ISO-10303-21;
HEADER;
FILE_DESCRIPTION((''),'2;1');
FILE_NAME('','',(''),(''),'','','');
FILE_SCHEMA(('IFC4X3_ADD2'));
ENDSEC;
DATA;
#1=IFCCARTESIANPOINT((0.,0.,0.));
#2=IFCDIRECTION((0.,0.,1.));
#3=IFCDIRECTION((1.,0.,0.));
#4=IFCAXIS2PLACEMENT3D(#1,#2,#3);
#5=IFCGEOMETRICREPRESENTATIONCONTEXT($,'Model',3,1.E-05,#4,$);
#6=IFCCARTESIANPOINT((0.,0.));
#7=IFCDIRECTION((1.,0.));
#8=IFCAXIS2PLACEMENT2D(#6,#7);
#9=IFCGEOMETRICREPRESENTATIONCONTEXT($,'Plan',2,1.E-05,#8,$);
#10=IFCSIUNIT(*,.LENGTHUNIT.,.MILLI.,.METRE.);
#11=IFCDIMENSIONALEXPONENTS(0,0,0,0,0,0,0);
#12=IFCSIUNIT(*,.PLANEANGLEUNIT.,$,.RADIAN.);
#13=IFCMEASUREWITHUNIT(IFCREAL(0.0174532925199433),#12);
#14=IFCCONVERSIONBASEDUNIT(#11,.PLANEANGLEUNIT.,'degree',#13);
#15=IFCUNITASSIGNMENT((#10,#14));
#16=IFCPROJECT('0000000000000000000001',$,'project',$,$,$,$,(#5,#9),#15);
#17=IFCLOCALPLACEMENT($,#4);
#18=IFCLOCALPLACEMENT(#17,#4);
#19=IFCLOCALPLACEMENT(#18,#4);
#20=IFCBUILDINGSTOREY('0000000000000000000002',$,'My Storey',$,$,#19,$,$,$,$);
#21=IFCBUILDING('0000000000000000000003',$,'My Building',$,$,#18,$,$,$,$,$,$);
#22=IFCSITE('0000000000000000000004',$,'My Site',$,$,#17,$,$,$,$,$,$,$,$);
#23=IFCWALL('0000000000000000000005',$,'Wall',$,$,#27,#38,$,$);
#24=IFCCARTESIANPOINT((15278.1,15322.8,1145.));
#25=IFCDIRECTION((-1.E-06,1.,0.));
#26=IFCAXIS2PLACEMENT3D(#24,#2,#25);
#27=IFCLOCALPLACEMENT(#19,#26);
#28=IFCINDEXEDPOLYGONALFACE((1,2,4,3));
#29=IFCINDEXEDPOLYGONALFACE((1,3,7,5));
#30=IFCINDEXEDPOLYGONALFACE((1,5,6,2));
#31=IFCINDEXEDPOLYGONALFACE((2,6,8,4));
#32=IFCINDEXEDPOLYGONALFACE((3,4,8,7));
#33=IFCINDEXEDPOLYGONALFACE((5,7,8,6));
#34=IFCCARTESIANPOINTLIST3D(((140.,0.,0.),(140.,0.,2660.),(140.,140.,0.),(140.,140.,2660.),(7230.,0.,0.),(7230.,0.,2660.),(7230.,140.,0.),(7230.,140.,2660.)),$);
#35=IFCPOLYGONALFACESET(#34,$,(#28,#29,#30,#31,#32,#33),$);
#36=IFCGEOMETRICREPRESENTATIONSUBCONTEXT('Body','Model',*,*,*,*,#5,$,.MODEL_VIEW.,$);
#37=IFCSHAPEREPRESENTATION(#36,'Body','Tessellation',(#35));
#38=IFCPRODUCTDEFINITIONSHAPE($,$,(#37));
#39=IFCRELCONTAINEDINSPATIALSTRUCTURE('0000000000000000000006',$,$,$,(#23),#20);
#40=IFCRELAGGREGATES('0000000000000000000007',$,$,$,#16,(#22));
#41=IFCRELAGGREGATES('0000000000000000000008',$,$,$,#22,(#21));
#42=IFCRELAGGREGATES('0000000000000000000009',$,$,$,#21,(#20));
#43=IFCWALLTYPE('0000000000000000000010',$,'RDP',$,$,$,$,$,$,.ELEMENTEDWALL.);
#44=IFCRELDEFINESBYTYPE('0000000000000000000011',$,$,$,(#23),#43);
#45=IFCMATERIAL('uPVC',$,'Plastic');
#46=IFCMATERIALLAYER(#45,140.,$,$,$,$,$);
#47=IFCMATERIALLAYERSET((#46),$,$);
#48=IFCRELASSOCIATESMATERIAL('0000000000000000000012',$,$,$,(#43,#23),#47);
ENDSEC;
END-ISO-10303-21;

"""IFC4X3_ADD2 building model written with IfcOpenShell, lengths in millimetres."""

from ifc_helpers import new_model, entity, si_unit, converted_unit, frame, origin_with_axes, origin_2d_with_axis, place, context, subcontext, project, spatial, line, indexed_curve, outline, extrude, material, layer, layer_set, layer_usage, type_object, element, save


model = new_model("IFC4X3_ADD2")

# Units and contexts
model_context = context("Model", 3, precision=1e-05, world=origin_with_axes())
plan_context = context("Plan", 2, precision=1e-05, world=origin_2d_with_axis())
body_context_1 = subcontext(model_context, "Body", "Model", "MODEL_VIEW")
ifc_project = project(units=[si_unit("LENGTHUNIT", "METRE", prefix="MILLI"), converted_unit("PLANEANGLEUNIT", "degree", entity("IfcReal", 0.0174532925199433), si_unit("PLANEANGLEUNIT", "RADIAN"), dimensions=[0, 0, 0, 0, 0, 0, 0])], contexts=[model_context, plan_context])

# Site, building, storey
site_placement = place(None, origin_with_axes())
site = spatial("IfcSite", under=ifc_project, at=site_placement, Name="My Site")
building_placement = place(site_placement, origin_with_axes())
building = spatial("IfcBuilding", under=site, at=building_placement, Name="My Building")
storey_placement = place(building_placement, origin_with_axes())
storey = spatial("IfcBuildingStorey", under=building, at=storey_placement, Name="My Storey")

# Shared definitions
ifc_material_1 = material(Name="uPVC", Category="Plastic")
ifc_layer_1 = layer(ifc_material_1, 140.0)
ifc_layer_set_1 = layer_set([ifc_layer_1])
wall_type_1 = type_object("IfcWallType", Name="RDP", PredefinedType="ELEMENTEDWALL", material=ifc_layer_set_1)

# Wall
ifc_layer_usage_1 = layer_usage(ifc_layer_set_1, "AXIS2", "POSITIVE", 0.0)
wall_1_placement = place(storey_placement, frame((15278.1, 15322.8, 1145.0), z_axis=(0.0, 0.0, 1.0), x_axis=(-0.000001, 1.0, 0.0)))
element("IfcWall", 1, at=wall_1_placement, inside=storey, type_object=wall_type_1, material=ifc_layer_usage_1, Name="Wall", context=body_context_1, shape_type="SweptSolid", body=[
    extrude(outline(indexed_curve([(140.0, 0.0), (140.0, 140.0), (7230.0, 140.0), (7230.0, 0.0)], segments=[line(1, 2, 3, 4, 1)])), origin_with_axes(), (0.0, 0.0, 1.0), 2660.0),
])

save(model, "model.ifc")
